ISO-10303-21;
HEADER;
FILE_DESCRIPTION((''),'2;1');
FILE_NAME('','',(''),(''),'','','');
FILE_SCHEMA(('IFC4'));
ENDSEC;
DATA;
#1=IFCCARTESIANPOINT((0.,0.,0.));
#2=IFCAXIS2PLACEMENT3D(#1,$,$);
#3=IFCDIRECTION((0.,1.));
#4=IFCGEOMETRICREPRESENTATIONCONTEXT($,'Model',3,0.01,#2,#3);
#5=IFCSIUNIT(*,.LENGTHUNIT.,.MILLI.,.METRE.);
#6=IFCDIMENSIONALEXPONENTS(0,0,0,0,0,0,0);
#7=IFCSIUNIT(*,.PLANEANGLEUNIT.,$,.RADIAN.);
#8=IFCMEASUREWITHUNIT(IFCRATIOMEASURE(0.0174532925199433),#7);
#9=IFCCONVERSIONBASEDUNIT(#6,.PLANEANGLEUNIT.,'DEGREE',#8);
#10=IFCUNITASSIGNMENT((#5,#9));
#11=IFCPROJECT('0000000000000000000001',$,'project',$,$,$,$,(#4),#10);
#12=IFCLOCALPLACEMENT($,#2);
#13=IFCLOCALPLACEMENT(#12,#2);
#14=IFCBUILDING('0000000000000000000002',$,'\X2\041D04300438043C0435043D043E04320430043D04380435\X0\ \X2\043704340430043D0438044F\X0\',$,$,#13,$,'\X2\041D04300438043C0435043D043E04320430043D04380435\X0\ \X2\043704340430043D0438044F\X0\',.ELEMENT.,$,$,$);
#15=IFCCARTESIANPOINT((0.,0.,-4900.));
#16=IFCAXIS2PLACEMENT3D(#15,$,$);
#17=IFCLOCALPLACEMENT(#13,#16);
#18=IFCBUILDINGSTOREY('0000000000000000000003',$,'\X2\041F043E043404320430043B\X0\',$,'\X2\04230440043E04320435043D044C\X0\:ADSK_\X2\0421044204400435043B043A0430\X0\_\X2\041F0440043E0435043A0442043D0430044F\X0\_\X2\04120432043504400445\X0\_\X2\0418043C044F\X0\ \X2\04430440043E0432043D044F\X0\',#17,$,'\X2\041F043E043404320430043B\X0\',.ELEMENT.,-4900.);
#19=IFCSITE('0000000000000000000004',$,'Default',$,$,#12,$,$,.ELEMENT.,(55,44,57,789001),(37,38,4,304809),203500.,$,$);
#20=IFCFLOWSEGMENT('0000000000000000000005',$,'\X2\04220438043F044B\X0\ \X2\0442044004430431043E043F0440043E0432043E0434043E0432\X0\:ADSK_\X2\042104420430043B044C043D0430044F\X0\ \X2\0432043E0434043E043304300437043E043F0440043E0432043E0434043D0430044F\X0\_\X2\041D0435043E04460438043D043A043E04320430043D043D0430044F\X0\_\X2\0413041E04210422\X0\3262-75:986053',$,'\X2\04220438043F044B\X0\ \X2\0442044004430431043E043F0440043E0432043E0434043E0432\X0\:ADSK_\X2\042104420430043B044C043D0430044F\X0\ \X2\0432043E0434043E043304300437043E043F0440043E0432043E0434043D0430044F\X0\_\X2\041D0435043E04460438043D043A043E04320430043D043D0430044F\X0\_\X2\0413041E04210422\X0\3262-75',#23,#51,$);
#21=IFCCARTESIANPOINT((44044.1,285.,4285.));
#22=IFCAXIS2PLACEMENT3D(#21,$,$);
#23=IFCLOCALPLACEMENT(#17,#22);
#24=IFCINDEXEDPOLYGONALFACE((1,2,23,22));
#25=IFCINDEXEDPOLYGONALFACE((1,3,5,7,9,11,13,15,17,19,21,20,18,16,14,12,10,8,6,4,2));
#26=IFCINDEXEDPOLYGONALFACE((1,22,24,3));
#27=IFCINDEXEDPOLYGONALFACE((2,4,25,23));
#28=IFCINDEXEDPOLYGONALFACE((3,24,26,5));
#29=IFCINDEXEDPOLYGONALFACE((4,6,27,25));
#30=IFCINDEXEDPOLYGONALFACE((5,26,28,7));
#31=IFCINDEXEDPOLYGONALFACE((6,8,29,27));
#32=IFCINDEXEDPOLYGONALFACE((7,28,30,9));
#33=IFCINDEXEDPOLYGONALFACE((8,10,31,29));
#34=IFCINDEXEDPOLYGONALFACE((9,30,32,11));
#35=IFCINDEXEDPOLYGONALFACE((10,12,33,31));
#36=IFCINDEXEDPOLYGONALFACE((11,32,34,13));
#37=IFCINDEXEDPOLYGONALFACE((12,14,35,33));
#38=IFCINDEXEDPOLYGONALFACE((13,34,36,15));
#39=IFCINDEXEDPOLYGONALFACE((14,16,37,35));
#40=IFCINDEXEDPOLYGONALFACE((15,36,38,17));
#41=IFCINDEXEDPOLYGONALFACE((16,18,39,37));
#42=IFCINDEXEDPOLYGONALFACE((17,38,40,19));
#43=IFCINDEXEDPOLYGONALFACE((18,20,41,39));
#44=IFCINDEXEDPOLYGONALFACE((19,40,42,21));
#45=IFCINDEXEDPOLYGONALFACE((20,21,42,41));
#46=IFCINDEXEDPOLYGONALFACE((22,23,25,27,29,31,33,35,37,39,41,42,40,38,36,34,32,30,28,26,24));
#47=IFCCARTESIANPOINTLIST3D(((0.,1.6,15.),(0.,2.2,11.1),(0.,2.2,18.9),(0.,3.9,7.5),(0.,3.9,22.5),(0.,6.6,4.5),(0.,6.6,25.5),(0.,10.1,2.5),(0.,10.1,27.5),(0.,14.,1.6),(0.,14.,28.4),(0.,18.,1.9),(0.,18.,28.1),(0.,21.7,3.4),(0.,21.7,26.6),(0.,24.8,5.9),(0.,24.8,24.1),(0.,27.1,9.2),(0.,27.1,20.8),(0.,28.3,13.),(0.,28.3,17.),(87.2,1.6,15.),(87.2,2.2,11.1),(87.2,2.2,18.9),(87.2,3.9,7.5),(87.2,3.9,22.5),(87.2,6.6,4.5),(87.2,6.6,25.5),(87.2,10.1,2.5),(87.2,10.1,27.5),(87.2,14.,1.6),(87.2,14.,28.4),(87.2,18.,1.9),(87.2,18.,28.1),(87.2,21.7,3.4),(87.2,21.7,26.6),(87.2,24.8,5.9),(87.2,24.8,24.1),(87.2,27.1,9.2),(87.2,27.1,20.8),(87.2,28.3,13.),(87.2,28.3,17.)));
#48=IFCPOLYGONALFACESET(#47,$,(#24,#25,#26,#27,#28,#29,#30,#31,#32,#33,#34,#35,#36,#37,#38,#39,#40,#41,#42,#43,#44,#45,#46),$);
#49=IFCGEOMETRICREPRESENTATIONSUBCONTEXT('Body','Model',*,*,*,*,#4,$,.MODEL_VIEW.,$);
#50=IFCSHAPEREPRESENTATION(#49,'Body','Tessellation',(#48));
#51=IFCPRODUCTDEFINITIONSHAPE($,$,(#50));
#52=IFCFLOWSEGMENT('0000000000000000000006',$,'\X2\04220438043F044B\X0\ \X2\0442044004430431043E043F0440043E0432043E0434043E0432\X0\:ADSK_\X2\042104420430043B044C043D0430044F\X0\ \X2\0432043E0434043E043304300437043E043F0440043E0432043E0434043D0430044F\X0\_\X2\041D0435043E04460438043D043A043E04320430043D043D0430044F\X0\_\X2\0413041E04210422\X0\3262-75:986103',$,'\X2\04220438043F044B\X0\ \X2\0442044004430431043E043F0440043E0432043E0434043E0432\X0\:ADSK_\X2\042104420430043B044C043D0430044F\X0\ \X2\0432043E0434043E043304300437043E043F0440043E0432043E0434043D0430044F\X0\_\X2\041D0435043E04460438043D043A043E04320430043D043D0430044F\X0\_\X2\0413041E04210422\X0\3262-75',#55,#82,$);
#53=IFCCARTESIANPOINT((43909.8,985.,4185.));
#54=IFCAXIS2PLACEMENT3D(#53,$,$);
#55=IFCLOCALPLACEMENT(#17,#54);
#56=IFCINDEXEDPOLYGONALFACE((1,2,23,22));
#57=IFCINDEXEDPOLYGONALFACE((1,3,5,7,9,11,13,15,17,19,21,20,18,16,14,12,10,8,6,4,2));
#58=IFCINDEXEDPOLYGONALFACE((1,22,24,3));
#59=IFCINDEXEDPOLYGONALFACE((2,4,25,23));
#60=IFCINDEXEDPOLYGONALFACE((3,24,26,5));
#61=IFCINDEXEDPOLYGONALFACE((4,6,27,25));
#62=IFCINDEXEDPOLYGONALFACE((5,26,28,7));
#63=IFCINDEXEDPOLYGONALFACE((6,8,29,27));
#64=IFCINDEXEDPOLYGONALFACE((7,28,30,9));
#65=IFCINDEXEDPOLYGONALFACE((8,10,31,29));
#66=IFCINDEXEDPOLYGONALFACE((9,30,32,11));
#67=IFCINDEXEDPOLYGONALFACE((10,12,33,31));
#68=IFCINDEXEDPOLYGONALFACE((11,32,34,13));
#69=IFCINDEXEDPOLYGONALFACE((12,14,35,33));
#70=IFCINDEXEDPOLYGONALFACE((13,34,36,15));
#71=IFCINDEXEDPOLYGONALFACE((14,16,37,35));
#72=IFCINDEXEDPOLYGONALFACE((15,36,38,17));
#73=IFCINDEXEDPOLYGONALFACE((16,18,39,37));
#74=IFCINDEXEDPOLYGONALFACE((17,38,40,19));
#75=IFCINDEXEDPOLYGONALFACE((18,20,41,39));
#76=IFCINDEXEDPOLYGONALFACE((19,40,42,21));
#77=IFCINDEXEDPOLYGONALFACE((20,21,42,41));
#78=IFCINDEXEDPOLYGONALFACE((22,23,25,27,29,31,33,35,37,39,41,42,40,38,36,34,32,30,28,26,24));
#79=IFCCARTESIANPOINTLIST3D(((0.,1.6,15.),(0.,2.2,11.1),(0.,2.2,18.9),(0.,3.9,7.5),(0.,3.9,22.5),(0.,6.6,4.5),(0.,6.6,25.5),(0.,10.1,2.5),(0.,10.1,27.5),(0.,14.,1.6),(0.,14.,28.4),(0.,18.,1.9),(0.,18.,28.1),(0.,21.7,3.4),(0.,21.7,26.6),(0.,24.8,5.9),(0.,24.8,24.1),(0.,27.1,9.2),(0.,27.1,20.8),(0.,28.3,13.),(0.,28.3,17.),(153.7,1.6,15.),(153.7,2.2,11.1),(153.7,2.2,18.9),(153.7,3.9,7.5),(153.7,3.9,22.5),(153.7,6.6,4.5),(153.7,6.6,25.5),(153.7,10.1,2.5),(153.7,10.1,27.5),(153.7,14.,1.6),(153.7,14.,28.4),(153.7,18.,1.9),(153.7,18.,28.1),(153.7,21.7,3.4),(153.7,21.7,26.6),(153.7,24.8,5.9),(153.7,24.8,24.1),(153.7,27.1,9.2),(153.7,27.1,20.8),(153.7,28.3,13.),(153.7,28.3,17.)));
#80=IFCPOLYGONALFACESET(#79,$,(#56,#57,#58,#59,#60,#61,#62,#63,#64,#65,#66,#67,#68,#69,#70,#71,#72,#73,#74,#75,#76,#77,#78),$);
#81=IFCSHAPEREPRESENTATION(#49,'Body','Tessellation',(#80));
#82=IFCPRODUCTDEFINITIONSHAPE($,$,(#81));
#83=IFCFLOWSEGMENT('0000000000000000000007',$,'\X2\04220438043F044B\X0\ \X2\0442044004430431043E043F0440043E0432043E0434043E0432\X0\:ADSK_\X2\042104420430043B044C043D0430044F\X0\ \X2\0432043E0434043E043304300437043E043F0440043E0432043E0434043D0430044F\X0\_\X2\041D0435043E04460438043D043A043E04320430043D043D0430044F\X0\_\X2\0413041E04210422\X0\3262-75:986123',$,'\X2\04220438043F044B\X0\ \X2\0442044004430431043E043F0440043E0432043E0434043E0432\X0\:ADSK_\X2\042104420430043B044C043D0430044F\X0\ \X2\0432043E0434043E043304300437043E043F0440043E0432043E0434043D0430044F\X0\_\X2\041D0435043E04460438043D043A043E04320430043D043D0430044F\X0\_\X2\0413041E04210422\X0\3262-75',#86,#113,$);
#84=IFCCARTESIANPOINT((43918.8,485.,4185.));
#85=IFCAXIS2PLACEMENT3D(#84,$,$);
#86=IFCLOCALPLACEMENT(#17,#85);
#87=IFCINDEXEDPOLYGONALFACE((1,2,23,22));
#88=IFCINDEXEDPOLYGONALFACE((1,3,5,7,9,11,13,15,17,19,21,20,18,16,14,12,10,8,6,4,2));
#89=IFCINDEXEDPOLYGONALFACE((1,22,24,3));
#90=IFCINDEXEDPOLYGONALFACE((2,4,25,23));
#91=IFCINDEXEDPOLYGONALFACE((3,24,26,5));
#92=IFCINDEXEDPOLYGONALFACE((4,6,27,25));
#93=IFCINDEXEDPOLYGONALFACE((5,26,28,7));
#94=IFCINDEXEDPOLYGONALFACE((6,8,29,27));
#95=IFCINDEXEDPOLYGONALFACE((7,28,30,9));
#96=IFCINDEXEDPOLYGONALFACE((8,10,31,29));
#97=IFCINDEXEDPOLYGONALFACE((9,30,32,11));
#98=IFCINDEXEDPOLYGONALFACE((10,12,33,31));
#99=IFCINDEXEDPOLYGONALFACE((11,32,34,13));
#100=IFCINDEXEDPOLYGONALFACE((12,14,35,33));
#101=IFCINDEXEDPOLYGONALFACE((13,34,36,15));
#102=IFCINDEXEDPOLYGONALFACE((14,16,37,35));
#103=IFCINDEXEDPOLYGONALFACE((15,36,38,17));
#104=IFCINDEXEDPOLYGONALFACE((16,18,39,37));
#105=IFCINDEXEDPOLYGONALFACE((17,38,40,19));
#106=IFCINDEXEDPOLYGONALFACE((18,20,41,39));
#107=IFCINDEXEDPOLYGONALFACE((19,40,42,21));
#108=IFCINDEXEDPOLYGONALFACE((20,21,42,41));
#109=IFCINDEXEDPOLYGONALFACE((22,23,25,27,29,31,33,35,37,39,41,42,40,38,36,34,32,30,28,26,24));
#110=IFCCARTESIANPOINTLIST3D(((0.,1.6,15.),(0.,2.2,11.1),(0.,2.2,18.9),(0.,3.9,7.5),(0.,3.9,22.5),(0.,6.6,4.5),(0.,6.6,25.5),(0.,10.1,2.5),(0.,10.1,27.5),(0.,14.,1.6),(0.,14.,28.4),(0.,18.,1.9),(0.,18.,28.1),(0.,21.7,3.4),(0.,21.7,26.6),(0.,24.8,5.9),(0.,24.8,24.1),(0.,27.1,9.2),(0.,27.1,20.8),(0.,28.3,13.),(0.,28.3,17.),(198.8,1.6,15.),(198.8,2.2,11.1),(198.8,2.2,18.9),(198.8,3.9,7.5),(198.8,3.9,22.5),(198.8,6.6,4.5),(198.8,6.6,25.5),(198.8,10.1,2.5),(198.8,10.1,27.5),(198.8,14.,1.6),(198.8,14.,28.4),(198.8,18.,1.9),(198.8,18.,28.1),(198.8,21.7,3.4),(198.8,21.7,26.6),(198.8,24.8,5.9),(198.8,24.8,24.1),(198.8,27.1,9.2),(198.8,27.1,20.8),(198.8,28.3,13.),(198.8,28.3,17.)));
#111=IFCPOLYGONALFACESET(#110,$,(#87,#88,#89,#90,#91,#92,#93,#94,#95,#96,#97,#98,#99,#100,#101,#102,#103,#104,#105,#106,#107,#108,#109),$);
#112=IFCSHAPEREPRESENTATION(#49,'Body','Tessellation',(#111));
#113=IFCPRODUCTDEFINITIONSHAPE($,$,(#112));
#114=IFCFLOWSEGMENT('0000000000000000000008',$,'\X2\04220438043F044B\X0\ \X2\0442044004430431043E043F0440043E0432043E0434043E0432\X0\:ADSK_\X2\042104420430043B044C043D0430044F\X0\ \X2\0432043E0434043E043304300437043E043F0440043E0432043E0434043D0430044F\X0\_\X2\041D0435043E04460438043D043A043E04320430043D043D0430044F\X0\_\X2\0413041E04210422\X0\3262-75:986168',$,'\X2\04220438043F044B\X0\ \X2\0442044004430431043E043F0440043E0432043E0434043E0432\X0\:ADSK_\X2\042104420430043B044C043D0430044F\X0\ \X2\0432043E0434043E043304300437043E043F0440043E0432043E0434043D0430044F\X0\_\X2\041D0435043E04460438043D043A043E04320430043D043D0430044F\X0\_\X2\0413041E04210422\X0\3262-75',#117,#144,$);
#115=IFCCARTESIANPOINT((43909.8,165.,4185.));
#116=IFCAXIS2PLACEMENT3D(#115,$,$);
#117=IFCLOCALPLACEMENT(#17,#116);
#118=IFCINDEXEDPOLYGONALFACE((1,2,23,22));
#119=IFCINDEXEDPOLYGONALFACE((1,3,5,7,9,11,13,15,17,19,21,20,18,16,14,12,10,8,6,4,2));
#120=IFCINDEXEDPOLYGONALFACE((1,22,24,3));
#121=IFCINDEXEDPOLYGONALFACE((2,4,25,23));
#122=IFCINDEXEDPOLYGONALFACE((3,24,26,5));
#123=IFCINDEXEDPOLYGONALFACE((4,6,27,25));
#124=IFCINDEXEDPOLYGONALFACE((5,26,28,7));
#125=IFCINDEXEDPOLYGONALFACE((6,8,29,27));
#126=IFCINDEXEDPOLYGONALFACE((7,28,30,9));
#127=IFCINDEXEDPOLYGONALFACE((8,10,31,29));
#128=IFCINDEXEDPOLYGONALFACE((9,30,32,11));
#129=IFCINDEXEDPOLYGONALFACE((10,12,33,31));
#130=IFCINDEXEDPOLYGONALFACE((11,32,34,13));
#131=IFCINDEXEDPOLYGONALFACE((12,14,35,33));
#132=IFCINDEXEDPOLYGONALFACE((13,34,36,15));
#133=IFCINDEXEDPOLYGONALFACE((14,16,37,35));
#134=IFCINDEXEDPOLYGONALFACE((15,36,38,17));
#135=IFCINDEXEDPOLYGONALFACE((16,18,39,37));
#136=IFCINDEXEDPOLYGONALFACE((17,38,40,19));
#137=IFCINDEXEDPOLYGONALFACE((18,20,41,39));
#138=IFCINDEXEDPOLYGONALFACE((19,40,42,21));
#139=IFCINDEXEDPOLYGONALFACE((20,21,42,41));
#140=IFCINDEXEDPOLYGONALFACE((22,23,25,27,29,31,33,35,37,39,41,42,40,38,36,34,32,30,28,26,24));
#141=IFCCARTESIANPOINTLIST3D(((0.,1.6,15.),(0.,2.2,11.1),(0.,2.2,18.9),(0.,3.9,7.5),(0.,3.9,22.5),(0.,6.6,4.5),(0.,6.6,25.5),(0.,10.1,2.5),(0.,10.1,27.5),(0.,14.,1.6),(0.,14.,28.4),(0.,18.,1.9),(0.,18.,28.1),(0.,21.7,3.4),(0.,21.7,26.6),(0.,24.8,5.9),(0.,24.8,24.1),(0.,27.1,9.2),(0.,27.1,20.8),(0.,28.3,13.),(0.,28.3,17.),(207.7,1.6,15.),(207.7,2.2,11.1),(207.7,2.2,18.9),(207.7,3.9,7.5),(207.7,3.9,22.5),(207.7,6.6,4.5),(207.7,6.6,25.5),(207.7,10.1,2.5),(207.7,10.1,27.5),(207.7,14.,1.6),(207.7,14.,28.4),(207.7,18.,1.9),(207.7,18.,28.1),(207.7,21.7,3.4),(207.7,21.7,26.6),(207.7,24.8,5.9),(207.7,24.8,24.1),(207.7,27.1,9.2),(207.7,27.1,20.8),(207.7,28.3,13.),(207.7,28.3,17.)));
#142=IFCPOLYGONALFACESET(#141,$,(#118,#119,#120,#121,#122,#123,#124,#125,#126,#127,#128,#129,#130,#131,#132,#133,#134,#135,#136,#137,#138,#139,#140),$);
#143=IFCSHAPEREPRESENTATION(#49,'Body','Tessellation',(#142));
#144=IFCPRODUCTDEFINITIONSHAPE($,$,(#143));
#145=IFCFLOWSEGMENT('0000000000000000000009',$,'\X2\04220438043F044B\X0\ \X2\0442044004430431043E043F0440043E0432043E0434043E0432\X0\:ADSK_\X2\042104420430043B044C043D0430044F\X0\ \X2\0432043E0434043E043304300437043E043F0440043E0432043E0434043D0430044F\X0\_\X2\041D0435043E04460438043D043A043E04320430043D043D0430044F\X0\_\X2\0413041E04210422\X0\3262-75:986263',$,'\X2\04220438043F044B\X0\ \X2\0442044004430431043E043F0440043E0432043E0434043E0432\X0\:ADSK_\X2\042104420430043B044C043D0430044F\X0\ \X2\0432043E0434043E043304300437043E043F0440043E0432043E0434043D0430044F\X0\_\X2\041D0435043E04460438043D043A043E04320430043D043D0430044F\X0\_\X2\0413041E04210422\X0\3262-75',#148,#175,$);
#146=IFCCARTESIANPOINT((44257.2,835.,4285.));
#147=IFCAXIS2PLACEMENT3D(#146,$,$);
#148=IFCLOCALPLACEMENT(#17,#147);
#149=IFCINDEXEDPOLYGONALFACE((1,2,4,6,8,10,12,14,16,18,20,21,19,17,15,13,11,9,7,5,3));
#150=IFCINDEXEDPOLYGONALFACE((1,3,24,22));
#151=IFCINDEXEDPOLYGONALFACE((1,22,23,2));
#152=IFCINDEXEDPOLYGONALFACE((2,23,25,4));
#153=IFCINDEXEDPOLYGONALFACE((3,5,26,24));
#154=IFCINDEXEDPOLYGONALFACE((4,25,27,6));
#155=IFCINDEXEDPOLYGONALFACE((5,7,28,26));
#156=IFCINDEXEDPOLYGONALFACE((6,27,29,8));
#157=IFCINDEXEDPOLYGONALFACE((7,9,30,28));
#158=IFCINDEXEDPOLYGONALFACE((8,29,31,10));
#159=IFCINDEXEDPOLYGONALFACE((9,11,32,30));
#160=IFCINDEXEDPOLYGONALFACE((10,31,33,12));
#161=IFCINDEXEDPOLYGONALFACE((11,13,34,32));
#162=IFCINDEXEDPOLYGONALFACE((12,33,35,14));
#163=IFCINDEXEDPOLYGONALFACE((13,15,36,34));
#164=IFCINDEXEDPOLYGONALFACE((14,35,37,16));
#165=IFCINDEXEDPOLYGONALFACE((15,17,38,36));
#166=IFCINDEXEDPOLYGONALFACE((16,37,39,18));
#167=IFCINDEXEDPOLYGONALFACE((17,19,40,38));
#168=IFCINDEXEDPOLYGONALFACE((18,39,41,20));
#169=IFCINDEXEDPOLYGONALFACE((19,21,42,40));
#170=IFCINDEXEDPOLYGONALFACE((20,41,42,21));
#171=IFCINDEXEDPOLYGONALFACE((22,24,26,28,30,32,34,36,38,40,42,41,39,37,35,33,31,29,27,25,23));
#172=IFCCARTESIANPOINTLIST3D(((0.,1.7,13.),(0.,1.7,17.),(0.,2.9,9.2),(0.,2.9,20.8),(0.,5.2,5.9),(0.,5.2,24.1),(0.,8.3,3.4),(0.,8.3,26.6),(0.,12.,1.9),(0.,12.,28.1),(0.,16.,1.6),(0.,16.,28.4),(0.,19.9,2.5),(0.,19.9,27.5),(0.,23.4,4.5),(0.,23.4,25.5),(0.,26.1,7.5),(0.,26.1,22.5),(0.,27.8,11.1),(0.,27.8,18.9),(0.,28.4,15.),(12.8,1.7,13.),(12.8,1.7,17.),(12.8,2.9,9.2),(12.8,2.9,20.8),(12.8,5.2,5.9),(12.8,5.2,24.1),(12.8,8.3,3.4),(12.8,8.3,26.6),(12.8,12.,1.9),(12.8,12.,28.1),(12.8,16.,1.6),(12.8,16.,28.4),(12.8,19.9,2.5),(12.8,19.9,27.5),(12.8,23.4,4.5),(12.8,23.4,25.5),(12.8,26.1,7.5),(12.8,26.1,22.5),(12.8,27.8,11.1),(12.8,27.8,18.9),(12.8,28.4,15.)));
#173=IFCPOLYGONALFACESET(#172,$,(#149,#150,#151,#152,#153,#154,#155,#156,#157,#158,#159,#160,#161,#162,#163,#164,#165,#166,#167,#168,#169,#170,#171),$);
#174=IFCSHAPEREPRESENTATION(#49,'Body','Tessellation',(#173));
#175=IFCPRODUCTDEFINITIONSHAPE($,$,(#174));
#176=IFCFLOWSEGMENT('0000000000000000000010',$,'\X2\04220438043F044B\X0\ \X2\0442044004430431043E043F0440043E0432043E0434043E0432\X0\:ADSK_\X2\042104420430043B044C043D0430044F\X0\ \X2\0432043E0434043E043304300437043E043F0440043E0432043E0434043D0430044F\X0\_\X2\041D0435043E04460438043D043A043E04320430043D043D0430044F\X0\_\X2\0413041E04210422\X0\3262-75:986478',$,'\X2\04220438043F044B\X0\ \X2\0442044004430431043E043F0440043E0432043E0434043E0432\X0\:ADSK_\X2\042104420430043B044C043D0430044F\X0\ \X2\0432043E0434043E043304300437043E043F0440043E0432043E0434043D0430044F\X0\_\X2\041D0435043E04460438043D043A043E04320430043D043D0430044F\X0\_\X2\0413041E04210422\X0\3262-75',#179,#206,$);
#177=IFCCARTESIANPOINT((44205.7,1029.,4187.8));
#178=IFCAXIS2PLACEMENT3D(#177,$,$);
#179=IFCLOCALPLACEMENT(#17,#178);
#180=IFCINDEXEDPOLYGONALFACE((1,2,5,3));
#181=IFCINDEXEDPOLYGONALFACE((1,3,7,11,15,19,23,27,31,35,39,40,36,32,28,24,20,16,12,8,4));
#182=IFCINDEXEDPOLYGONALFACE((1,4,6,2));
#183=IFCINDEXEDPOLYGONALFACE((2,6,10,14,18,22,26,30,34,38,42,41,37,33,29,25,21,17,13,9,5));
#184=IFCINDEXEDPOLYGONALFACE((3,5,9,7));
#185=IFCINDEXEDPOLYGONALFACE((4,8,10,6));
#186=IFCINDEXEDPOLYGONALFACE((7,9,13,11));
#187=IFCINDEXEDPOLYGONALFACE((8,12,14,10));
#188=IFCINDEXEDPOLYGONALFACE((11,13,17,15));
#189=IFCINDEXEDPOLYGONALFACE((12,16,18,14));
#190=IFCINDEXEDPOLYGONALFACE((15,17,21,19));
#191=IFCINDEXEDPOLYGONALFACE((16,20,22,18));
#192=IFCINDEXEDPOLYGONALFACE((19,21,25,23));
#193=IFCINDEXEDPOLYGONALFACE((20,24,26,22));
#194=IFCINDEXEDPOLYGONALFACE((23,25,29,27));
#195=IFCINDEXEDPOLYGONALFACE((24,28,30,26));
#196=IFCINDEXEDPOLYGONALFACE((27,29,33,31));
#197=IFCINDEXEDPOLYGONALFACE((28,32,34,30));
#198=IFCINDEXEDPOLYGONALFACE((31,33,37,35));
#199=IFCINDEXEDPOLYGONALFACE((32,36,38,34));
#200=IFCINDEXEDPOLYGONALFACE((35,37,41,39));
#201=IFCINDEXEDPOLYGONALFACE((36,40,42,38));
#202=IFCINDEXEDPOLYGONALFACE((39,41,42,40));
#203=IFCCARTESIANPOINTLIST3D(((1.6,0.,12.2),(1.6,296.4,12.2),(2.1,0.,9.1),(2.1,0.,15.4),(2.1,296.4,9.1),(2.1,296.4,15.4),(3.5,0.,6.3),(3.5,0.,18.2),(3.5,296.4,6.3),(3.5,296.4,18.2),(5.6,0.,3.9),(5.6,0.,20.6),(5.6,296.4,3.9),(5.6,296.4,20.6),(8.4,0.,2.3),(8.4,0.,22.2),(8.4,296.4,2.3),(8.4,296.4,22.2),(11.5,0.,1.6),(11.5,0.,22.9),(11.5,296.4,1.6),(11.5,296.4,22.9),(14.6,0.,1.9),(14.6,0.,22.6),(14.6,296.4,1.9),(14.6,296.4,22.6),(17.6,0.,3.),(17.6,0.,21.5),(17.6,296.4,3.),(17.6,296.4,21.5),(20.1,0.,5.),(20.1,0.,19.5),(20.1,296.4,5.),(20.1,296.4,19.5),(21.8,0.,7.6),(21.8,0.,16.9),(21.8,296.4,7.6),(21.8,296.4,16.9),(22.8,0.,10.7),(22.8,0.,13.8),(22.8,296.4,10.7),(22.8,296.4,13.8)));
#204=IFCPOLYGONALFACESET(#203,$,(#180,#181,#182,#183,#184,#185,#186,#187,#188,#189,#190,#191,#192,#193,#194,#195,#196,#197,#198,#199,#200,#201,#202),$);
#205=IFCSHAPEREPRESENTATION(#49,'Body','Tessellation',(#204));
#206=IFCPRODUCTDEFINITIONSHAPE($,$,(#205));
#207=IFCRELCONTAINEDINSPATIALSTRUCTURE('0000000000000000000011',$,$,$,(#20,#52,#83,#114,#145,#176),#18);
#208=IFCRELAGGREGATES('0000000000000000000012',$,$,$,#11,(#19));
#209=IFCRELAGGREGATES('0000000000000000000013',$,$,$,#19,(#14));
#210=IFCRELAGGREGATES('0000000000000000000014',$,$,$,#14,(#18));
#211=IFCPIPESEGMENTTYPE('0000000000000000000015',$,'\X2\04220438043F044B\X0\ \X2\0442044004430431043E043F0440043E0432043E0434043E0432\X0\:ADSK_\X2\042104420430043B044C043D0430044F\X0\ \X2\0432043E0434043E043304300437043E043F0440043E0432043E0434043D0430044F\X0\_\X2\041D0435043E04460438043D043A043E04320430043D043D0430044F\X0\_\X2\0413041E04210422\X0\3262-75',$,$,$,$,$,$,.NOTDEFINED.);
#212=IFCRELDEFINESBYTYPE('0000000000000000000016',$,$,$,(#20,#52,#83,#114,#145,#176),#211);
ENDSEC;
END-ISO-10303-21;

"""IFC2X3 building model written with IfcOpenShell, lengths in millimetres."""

from ifc_helpers import new_model, entity, si_unit, converted_unit, direction, frame, origin, origin_2d_with_axis, place, context, subcontext, project, spatial, circle, extrude, type_object, element, save


model = new_model("IFC2X3")

# Units and contexts
model_context = context("Model", 3, precision=0.01, world=origin(), true_north=direction((0.0, 1.0)))
body_context = subcontext(model_context, "Body", "Model", "MODEL_VIEW")
ifc_project = project(units=[si_unit("LENGTHUNIT", "METRE", prefix="MILLI"), converted_unit("PLANEANGLEUNIT", "DEGREE", entity("IfcRatioMeasure", 0.0174532925199433), si_unit("PLANEANGLEUNIT", "RADIAN"), dimensions=[0, 0, 0, 0, 0, 0, 0])], contexts=[model_context])

# Site, building, storey
site_placement = place(None, origin())
site = spatial("IfcSite", under=ifc_project, at=site_placement, Name="Default", CompositionType="ELEMENT", RefLatitude=(55, 44, 57, 789001), RefLongitude=(37, 38, 4, 304809), RefElevation=203500.0)
building_placement = place(site_placement, origin())
building = spatial("IfcBuilding", under=site, at=building_placement, Name="Наименование здания", LongName="Наименование здания", CompositionType="ELEMENT")
storey_placement = place(building_placement, frame((0.0, 0.0, -4900.0)))
storey = spatial("IfcBuildingStorey", under=building, at=storey_placement, Name="Подвал", ObjectType="Уровень:ADSK_Стрелка_Проектная_Вверх_Имя уровня", LongName="Подвал", CompositionType="ELEMENT", Elevation=-4900.0)

# Flow segments
pipe_segment_type = type_object("IfcPipeSegmentType", Name="Типы трубопроводов:ADSK_Стальная водогазопроводная_Неоцинкованная_ГОСТ3262-75", PredefinedType="NOTDEFINED")
flow_segment_1_placement = place(storey_placement, frame((44044.1, 285.0, 4285.0)))
element("IfcFlowSegment", 1, at=flow_segment_1_placement, inside=storey, type_object=pipe_segment_type, Name="Типы трубопроводов:ADSK_Стальная водогазопроводная_Неоцинкованная_ГОСТ3262-75:986053", ObjectType="Типы трубопроводов:ADSK_Стальная водогазопроводная_Неоцинкованная_ГОСТ3262-75", context=body_context, shape_type="SweptSolid", body=[
    extrude(circle(Radius=13.4, at=origin_2d_with_axis()), frame((0.0, 15.0, 15.0), z_axis=(1.0, 0.0, 0.0), x_axis=(0.0, -1.0, 0.0)), (0.0, 0.0, 1.0), 87.2),
])
flow_segment_2_placement = place(storey_placement, frame((43909.8, 985.0, 4185.0)))
element("IfcFlowSegment", 2, at=flow_segment_2_placement, inside=storey, type_object=pipe_segment_type, Name="Типы трубопроводов:ADSK_Стальная водогазопроводная_Неоцинкованная_ГОСТ3262-75:986103", ObjectType="Типы трубопроводов:ADSK_Стальная водогазопроводная_Неоцинкованная_ГОСТ3262-75", context=body_context, shape_type="SweptSolid", body=[
    extrude(circle(Radius=13.4, at=origin_2d_with_axis()), frame((0.0, 15.0, 15.0), z_axis=(1.0, 0.0, 0.0), x_axis=(0.0, -1.0, 0.0)), (0.0, 0.0, 1.0), 153.7),
])
flow_segment_3_placement = place(storey_placement, frame((43918.8, 485.0, 4185.0)))
element("IfcFlowSegment", 3, at=flow_segment_3_placement, inside=storey, type_object=pipe_segment_type, Name="Типы трубопроводов:ADSK_Стальная водогазопроводная_Неоцинкованная_ГОСТ3262-75:986123", ObjectType="Типы трубопроводов:ADSK_Стальная водогазопроводная_Неоцинкованная_ГОСТ3262-75", context=body_context, shape_type="SweptSolid", body=[
    extrude(circle(Radius=13.4, at=origin_2d_with_axis()), frame((0.0, 15.0, 15.0), z_axis=(1.0, 0.0, 0.0), x_axis=(0.0, -1.0, 0.0)), (0.0, 0.0, 1.0), 198.8),
])
flow_segment_4_placement = place(storey_placement, frame((43909.8, 165.0, 4185.0)))
element("IfcFlowSegment", 4, at=flow_segment_4_placement, inside=storey, type_object=pipe_segment_type, Name="Типы трубопроводов:ADSK_Стальная водогазопроводная_Неоцинкованная_ГОСТ3262-75:986168", ObjectType="Типы трубопроводов:ADSK_Стальная водогазопроводная_Неоцинкованная_ГОСТ3262-75", context=body_context, shape_type="SweptSolid", body=[
    extrude(circle(Radius=13.4, at=origin_2d_with_axis()), frame((0.0, 15.0, 15.0), z_axis=(1.0, 0.0, 0.0), x_axis=(0.0, -1.0, 0.0)), (0.0, 0.0, 1.0), 207.7),
])
flow_segment_5_placement = place(storey_placement, frame((44257.2, 835.0, 4285.0)))
element("IfcFlowSegment", 5, at=flow_segment_5_placement, inside=storey, type_object=pipe_segment_type, Name="Типы трубопроводов:ADSK_Стальная водогазопроводная_Неоцинкованная_ГОСТ3262-75:986263", ObjectType="Типы трубопроводов:ADSK_Стальная водогазопроводная_Неоцинкованная_ГОСТ3262-75", context=body_context, shape_type="SweptSolid", body=[
    extrude(circle(Radius=13.4, at=origin_2d_with_axis()), frame((0.0, 15.0, 15.0), z_axis=(1.0, 0.0, 0.0), x_axis=(0.0, 1.0, 0.0)), (0.0, 0.0, 1.0), 12.8),
])
flow_segment_6_placement = place(storey_placement, frame((44205.7, 1029.0, 4187.8)))
element("IfcFlowSegment", 6, at=flow_segment_6_placement, inside=storey, type_object=pipe_segment_type, Name="Типы трубопроводов:ADSK_Стальная водогазопроводная_Неоцинкованная_ГОСТ3262-75:986478", ObjectType="Типы трубопроводов:ADSK_Стальная водогазопроводная_Неоцинкованная_ГОСТ3262-75", context=body_context, shape_type="SweptSolid", body=[
    extrude(circle(Radius=10.7, at=origin_2d_with_axis()), frame((12.2, 0.0, 12.2), z_axis=(0.0, 1.0, 0.0), x_axis=(-1.0, 0.0, 0.0)), (0.0, 0.0, 1.0), 296.4),
])

save(model, "model.ifc")
